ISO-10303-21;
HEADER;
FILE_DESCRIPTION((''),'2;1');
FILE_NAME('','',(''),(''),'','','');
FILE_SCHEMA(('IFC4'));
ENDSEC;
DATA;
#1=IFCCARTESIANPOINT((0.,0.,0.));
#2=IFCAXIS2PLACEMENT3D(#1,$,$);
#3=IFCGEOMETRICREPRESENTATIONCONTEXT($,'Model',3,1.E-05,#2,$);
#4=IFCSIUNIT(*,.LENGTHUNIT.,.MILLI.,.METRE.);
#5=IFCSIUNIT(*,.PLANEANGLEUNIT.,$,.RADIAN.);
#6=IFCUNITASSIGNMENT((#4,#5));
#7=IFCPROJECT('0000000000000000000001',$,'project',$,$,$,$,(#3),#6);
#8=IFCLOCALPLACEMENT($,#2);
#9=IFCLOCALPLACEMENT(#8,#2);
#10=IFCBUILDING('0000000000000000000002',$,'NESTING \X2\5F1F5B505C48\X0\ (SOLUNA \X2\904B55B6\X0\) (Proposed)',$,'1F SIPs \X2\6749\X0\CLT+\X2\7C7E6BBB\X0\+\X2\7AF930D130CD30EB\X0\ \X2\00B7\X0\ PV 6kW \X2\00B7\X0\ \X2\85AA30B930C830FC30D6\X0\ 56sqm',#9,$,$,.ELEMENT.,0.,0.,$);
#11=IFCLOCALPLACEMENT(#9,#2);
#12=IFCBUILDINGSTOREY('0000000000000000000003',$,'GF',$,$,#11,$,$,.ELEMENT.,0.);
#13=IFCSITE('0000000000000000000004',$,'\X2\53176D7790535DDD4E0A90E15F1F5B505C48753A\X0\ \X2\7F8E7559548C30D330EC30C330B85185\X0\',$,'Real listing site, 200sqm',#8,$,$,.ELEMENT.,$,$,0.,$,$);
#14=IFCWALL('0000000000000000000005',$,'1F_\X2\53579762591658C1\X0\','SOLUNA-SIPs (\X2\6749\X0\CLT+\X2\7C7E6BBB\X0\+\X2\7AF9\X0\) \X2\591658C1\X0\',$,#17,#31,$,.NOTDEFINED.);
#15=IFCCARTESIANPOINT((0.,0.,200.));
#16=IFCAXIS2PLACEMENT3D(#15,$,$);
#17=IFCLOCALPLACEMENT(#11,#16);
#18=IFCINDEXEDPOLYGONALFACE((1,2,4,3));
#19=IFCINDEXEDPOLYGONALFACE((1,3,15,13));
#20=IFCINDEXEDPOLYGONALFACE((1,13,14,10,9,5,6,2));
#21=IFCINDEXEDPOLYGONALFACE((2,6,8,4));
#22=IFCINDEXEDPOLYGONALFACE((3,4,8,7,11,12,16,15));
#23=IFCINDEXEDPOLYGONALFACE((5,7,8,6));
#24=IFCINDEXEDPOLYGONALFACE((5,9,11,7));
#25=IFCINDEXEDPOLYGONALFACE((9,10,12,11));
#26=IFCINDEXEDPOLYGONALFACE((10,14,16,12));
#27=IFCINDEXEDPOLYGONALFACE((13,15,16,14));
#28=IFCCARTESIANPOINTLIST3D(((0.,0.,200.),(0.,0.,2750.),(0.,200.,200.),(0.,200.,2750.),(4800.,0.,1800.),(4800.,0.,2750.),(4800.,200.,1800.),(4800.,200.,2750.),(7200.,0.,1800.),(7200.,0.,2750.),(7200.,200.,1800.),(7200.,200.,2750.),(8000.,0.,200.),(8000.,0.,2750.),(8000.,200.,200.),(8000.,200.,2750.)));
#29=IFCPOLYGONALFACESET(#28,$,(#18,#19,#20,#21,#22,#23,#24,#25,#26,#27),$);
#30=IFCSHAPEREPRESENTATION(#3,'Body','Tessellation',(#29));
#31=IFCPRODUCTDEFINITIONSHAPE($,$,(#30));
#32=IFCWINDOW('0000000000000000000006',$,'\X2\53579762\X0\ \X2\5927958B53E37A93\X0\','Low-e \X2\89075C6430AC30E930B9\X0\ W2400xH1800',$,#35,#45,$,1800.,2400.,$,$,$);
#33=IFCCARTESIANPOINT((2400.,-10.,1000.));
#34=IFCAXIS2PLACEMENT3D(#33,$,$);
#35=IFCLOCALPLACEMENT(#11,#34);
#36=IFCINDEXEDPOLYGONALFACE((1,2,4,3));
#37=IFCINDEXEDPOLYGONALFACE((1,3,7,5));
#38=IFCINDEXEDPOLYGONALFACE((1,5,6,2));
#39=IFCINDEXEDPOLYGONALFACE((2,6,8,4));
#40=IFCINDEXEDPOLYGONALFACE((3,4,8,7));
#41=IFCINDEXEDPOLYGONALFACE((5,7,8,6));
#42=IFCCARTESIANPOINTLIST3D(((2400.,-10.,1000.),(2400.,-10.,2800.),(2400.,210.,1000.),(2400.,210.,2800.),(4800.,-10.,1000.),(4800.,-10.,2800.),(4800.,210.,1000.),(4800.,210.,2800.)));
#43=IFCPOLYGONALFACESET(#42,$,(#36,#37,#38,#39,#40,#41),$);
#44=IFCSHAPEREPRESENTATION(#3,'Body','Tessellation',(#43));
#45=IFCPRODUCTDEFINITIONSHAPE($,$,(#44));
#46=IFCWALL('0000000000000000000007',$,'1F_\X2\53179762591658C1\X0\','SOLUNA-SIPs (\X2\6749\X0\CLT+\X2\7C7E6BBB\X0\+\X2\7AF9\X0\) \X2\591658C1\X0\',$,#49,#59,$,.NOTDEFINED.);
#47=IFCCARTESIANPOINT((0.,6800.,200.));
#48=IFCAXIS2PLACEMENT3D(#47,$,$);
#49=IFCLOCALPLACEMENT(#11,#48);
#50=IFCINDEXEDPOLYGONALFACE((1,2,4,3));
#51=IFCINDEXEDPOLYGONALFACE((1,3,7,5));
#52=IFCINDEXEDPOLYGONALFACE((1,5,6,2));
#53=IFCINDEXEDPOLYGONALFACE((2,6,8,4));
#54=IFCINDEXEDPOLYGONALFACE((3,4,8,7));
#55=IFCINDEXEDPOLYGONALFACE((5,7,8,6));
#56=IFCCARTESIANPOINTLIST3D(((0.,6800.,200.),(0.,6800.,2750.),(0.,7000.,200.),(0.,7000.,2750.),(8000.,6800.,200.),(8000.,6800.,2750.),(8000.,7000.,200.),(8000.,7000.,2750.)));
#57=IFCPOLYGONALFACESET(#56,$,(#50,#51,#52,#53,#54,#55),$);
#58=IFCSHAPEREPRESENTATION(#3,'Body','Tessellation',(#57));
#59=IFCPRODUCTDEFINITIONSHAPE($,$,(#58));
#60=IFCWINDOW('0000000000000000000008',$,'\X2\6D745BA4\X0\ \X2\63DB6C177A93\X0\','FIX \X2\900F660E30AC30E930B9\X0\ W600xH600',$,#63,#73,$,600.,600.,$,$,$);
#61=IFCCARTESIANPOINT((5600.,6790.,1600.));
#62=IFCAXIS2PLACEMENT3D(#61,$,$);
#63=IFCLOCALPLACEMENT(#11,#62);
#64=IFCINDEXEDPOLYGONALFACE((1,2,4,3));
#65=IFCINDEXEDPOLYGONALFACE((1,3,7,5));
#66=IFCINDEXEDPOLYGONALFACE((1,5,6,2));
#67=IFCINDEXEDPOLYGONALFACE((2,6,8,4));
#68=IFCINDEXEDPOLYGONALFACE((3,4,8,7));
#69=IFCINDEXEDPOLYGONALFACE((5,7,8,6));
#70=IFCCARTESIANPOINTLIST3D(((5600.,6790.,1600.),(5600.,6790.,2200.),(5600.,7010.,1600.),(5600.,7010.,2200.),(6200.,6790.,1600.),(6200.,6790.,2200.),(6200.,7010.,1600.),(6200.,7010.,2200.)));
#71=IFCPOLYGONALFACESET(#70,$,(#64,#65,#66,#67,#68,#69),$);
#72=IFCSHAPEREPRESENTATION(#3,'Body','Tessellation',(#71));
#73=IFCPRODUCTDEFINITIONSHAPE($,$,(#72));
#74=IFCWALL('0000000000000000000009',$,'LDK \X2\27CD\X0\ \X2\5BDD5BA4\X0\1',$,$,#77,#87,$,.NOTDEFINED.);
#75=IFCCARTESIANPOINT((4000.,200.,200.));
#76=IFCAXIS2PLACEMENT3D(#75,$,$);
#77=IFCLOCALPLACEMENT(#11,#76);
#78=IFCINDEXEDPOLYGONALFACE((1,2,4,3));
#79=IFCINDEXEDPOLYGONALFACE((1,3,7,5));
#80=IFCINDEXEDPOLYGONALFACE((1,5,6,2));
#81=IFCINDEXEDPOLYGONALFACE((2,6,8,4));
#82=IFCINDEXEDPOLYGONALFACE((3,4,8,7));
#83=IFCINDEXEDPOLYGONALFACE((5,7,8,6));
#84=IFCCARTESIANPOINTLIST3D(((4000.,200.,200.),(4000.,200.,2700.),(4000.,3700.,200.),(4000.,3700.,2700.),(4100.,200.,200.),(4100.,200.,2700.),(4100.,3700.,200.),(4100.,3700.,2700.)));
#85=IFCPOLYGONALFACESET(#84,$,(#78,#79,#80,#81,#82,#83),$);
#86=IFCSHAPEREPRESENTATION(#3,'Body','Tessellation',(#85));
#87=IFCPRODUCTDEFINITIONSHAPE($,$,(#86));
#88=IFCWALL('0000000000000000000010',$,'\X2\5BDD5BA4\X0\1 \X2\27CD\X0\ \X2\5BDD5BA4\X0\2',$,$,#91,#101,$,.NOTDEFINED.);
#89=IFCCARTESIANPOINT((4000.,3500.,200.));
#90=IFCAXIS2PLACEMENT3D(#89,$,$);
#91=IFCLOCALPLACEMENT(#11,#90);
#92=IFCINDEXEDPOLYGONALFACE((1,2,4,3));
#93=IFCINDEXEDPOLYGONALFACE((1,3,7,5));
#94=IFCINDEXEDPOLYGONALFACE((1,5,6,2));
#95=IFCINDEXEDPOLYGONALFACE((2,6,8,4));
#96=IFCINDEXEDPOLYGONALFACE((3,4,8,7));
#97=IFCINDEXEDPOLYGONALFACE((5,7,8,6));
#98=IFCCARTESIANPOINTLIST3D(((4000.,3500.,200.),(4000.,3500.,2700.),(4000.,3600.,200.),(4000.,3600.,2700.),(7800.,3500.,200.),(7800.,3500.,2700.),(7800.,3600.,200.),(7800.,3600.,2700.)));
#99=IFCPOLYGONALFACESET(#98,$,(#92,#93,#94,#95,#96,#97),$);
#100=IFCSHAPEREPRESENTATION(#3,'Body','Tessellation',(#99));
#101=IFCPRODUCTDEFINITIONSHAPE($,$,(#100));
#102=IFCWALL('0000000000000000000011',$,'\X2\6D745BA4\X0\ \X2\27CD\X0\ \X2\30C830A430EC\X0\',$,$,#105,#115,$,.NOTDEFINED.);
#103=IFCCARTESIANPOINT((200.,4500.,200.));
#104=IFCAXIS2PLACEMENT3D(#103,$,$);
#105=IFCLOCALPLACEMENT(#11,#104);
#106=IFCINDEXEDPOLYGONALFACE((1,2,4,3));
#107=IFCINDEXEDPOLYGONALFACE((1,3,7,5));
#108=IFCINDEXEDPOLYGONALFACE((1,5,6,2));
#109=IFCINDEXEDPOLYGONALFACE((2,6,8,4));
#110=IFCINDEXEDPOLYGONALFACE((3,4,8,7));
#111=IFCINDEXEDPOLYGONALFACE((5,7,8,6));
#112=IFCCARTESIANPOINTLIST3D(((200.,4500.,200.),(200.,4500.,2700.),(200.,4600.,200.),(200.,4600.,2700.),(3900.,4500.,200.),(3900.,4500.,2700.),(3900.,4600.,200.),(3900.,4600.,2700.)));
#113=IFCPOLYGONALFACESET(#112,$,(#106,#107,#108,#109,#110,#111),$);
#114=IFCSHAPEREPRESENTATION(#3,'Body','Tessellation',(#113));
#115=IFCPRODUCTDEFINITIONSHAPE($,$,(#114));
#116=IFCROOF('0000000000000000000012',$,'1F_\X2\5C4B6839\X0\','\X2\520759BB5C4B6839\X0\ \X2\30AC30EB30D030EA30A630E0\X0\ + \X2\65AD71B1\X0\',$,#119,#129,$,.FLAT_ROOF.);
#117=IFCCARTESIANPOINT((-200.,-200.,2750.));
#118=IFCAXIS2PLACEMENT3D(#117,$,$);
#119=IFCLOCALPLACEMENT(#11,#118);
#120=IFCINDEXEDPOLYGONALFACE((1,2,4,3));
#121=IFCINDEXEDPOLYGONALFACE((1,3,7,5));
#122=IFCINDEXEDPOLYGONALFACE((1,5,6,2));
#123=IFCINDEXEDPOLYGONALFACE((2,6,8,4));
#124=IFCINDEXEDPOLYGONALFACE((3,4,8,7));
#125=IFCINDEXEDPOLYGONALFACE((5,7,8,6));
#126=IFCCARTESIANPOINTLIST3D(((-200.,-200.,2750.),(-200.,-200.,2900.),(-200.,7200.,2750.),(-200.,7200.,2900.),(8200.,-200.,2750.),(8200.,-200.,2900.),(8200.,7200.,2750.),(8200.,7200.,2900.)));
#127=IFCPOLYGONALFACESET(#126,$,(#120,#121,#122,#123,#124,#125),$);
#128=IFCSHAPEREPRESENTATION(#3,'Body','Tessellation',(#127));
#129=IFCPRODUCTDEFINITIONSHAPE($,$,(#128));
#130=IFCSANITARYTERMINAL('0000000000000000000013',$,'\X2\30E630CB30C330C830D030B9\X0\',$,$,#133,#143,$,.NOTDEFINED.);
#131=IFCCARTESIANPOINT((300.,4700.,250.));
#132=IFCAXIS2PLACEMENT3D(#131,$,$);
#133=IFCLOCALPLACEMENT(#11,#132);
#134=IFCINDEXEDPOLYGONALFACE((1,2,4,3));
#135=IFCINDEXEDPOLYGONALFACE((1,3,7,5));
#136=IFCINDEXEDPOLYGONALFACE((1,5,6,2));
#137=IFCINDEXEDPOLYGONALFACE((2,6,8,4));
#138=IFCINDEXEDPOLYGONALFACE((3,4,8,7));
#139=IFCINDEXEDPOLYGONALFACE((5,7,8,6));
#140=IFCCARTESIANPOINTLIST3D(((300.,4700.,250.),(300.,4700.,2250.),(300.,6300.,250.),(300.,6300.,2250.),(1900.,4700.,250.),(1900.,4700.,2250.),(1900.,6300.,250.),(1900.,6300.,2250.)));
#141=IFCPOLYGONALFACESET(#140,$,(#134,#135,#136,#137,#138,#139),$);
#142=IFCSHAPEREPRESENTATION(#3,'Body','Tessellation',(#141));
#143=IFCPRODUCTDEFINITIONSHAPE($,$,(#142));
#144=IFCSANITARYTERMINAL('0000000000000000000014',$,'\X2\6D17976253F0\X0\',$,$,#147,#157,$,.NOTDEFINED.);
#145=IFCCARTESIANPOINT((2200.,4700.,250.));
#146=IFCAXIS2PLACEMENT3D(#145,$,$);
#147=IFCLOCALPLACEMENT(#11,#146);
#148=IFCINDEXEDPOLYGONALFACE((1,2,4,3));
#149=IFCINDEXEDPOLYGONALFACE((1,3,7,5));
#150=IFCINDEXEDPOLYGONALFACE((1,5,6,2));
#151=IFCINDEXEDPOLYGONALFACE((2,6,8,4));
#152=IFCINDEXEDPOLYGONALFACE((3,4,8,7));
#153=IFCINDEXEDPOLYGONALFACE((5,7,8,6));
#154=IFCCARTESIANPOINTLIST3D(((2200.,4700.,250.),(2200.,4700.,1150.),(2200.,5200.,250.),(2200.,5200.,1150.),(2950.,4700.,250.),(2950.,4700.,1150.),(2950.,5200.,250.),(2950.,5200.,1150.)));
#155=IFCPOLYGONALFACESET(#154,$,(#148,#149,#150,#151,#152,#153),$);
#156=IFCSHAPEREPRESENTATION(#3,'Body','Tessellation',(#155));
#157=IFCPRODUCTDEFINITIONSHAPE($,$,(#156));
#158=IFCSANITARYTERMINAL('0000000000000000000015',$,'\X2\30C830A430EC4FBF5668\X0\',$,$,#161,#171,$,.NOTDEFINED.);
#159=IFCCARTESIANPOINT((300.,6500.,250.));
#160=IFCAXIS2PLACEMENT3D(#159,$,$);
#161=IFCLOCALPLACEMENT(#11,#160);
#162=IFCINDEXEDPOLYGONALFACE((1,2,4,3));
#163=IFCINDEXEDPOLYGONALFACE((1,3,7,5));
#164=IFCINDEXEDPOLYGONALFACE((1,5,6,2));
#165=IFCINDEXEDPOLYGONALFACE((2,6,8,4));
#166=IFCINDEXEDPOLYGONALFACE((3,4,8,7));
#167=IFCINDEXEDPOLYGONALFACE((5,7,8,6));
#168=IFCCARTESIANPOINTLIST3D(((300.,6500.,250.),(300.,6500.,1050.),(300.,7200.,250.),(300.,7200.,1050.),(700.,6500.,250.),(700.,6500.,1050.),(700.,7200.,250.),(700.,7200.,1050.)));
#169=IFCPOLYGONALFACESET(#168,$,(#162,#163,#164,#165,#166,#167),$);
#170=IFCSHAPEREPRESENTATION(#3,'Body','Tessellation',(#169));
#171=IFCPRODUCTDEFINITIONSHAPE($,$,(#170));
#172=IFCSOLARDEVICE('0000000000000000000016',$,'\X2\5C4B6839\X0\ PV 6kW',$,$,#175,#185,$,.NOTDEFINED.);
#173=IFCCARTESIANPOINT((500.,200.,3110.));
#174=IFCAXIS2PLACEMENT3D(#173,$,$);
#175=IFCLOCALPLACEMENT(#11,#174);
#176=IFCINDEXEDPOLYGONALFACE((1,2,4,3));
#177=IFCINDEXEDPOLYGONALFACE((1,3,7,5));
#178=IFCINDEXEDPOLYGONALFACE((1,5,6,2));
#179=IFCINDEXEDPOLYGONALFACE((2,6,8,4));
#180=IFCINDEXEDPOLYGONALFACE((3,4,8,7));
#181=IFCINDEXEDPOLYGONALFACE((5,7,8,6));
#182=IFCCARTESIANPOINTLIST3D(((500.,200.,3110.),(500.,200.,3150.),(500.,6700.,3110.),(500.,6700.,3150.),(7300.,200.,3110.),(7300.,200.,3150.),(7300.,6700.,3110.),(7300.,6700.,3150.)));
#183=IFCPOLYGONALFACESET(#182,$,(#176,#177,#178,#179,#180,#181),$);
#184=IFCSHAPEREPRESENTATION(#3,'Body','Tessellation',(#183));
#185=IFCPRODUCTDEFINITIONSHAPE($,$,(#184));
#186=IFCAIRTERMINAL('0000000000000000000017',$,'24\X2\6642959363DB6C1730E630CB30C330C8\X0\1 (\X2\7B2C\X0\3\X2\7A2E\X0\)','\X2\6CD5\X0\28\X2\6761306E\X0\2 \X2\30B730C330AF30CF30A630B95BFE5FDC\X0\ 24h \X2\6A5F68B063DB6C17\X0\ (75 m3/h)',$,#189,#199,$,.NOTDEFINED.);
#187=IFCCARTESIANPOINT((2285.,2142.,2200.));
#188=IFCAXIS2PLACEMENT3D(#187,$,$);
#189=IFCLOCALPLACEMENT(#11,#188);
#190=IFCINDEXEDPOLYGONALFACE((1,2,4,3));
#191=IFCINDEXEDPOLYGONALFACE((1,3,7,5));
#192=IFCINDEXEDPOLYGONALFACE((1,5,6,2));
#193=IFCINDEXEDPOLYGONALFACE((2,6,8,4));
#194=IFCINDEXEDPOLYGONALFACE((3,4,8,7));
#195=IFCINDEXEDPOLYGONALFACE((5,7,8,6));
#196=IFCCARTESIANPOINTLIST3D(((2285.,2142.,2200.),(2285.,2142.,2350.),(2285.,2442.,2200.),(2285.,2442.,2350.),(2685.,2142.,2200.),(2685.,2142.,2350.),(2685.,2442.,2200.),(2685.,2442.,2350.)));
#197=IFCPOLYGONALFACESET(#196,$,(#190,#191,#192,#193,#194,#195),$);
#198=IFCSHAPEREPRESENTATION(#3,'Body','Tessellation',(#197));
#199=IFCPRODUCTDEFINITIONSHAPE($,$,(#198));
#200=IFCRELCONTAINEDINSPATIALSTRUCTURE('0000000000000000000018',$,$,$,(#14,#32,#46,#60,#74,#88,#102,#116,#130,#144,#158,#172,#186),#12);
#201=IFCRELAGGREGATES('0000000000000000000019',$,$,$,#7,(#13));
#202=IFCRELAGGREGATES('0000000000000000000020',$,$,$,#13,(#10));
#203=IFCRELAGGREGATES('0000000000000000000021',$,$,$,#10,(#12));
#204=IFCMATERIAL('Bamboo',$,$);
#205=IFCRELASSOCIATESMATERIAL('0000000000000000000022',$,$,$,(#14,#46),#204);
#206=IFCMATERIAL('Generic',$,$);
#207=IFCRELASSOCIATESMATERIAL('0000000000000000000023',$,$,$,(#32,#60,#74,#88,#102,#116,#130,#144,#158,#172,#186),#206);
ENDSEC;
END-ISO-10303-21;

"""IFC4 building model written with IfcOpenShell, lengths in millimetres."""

from ifc_helpers import new_model, si_unit, frame, frame_2d, origin, place, context, project, spatial, rectangle, extrude, material, element, fill, save


model = new_model("IFC4")

# Units and contexts
model_context = context("Model", 3, precision=1e-05, world=origin())
ifc_project = project(units=[si_unit("LENGTHUNIT", "METRE", prefix="MILLI"), si_unit("PLANEANGLEUNIT", "RADIAN")], contexts=[model_context])

# Site, building, storey
site_placement = place(None, origin())
site = spatial("IfcSite", under=ifc_project, at=site_placement, Name="北海道川上郡弟子屈町 美留和ビレッジ内", ObjectType="Real listing site, 200sqm", CompositionType="ELEMENT", RefElevation=0.0)
building_placement = place(site_placement, origin())
building = spatial("IfcBuilding", under=site, at=building_placement, Name="NESTING 弟子屈 (SOLUNA 運営) (Proposed)", ObjectType="1F SIPs 杉CLT+籾殻+竹パネル · PV 6kW · 薪ストーブ 56sqm", CompositionType="ELEMENT", ElevationOfRefHeight=0.0, ElevationOfTerrain=0.0)
storey_placement = place(building_placement, origin())
storey = spatial("IfcBuildingStorey", under=building, at=storey_placement, Name="GF", CompositionType="ELEMENT", Elevation=0.0)

# Walls, openings, windows
ifc_material_1 = material(Name="Bamboo")
wall_1_placement = place(storey_placement, frame((0.0, 0.0, 200.0)))
wall_1 = element("IfcWall", 1, at=wall_1_placement, inside=storey, material=ifc_material_1, Name="1F_南面外壁", Description="SOLUNA-SIPs (杉CLT+籾殻+竹) 外壁", PredefinedType="NOTDEFINED", context=model_context, shape_type="SweptSolid", body=[
    extrude(rectangle(XDim=8000.0, YDim=200.0, at=frame_2d((4000.0, 100.0))), frame((0.0, 0.0, 200.0)), (0.0, 0.0, 1.0), 2550.0),
])
opening_1_placement = place(storey_placement, frame((2400.0, -10.0, 1000.0)))
opening_1 = element("IfcOpeningElement", 2, at=opening_1_placement, cuts=wall_1, PredefinedType="NOTDEFINED", context=model_context, shape_type="SweptSolid", body=[
    extrude(rectangle(XDim=2400.0, YDim=220.0, at=frame_2d((1200.0, 110.0))), frame((2400.0, -10.0, 1000.0)), (0.0, 0.0, 1.0), 1800.0),
])
ifc_material_2 = material(Name="Generic")
window_1_placement = place(storey_placement, frame((2400.0, -10.0, 1000.0)))
window_1 = element("IfcWindow", 3, at=window_1_placement, inside=storey, material=ifc_material_2, Name="南面 大開口窓", Description="Low-e 複層ガラス W2400xH1800", OverallHeight=1800.0, OverallWidth=2400.0, context=model_context, shape_type="SweptSolid", body=[
    extrude(rectangle(XDim=2400.0, YDim=220.0, at=frame_2d((1200.0, 110.0))), frame((2400.0, -10.0, 1000.0)), (0.0, 0.0, 1.0), 1800.0),
])
fill(opening_1, window_1)
wall_2_placement = place(storey_placement, frame((0.0, 6800.0, 200.0)))
wall_2 = element("IfcWall", 4, at=wall_2_placement, inside=storey, material=ifc_material_1, Name="1F_北面外壁", Description="SOLUNA-SIPs (杉CLT+籾殻+竹) 外壁", PredefinedType="NOTDEFINED", context=model_context, shape_type="SweptSolid", body=[
    extrude(rectangle(XDim=8000.0, YDim=200.0, at=frame_2d((4000.0, 100.0))), frame((0.0, 6800.0, 200.0)), (0.0, 0.0, 1.0), 2550.0),
])
opening_2_placement = place(storey_placement, frame((5600.0, 6790.0, 1600.0)))
opening_2 = element("IfcOpeningElement", 5, at=opening_2_placement, cuts=wall_2, PredefinedType="NOTDEFINED", context=model_context, shape_type="SweptSolid", body=[
    extrude(rectangle(XDim=600.0, YDim=220.0, at=frame_2d((300.0, 110.0))), frame((5600.0, 6790.0, 1600.0)), (0.0, 0.0, 1.0), 600.0),
])
window_2_placement = place(storey_placement, frame((5600.0, 6790.0, 1600.0)))
window_2 = element("IfcWindow", 6, at=window_2_placement, inside=storey, material=ifc_material_2, Name="浴室 換気窓", Description="FIX 透明ガラス W600xH600", OverallHeight=600.0, OverallWidth=600.0, context=model_context, shape_type="SweptSolid", body=[
    extrude(rectangle(XDim=600.0, YDim=220.0, at=frame_2d((300.0, 110.0))), frame((5600.0, 6790.0, 1600.0)), (0.0, 0.0, 1.0), 600.0),
])
fill(opening_2, window_2)

# Walls
wall_3_placement = place(storey_placement, frame((4000.0, 200.0, 200.0)))
element("IfcWall", 7, at=wall_3_placement, inside=storey, material=ifc_material_2, Name="LDK ⟍ 寝室1", PredefinedType="NOTDEFINED", context=model_context, shape_type="SweptSolid", body=[
    extrude(rectangle(XDim=100.0, YDim=3500.0, at=frame_2d((50.0, 1750.0))), frame((4000.0, 200.0, 200.0)), (0.0, 0.0, 1.0), 2500.0),
])
wall_4_placement = place(storey_placement, frame((4000.0, 3500.0, 200.0)))
element("IfcWall", 8, at=wall_4_placement, inside=storey, material=ifc_material_2, Name="寝室1 ⟍ 寝室2", PredefinedType="NOTDEFINED", context=model_context, shape_type="SweptSolid", body=[
    extrude(rectangle(XDim=3800.0, YDim=100.0, at=frame_2d((1900.0, 50.0))), frame((4000.0, 3500.0, 200.0)), (0.0, 0.0, 1.0), 2500.0),
])
wall_5_placement = place(storey_placement, frame((200.0, 4500.0, 200.0)))
element("IfcWall", 9, at=wall_5_placement, inside=storey, material=ifc_material_2, Name="浴室 ⟍ トイレ", PredefinedType="NOTDEFINED", context=model_context, shape_type="SweptSolid", body=[
    extrude(rectangle(XDim=3700.0, YDim=100.0, at=frame_2d((1850.0, 50.0))), frame((200.0, 4500.0, 200.0)), (0.0, 0.0, 1.0), 2500.0),
])

# Roof
roof_placement = place(storey_placement, frame((-200.0, -200.0, 2750.0)))
element("IfcRoof", 10, at=roof_placement, inside=storey, material=ifc_material_2, Name="1F_屋根", Description="切妻屋根 ガルバリウム + 断熱", PredefinedType="FLAT_ROOF", context=model_context, shape_type="SweptSolid", body=[
    extrude(rectangle(XDim=8400.0, YDim=7400.0, at=frame_2d((4200.0, 3700.0))), frame((-200.0, -200.0, 2750.0)), (0.0, 0.0, 1.0), 150.0),
])

# Sanitary terminals
sanitary_terminal_1_placement = place(storey_placement, frame((300.0, 4700.0, 250.0)))
element("IfcSanitaryTerminal", 11, at=sanitary_terminal_1_placement, inside=storey, material=ifc_material_2, Name="ユニットバス", PredefinedType="NOTDEFINED", context=model_context, shape_type="SweptSolid", body=[
    extrude(rectangle(XDim=1600.0, YDim=1600.0, at=frame_2d((800.0, 800.0))), frame((300.0, 4700.0, 250.0)), (0.0, 0.0, 1.0), 2000.0),
])
sanitary_terminal_2_placement = place(storey_placement, frame((2200.0, 4700.0, 250.0)))
element("IfcSanitaryTerminal", 12, at=sanitary_terminal_2_placement, inside=storey, material=ifc_material_2, Name="洗面台", PredefinedType="NOTDEFINED", context=model_context, shape_type="SweptSolid", body=[
    extrude(rectangle(XDim=750.0, YDim=500.0, at=frame_2d((375.0, 250.0))), frame((2200.0, 4700.0, 250.0)), (0.0, 0.0, 1.0), 900.0),
])
sanitary_terminal_3_placement = place(storey_placement, frame((300.0, 6500.0, 250.0)))
element("IfcSanitaryTerminal", 13, at=sanitary_terminal_3_placement, inside=storey, material=ifc_material_2, Name="トイレ便器", PredefinedType="NOTDEFINED", context=model_context, shape_type="SweptSolid", body=[
    extrude(rectangle(XDim=400.0, YDim=700.0, at=frame_2d((200.0, 350.0))), frame((300.0, 6500.0, 250.0)), (0.0, 0.0, 1.0), 800.0),
])

# Solar device
solar_device_placement = place(storey_placement, frame((500.0, 200.0, 3110.0)))
element("IfcSolarDevice", 14, at=solar_device_placement, inside=storey, material=ifc_material_2, Name="屋根 PV 6kW", PredefinedType="NOTDEFINED", context=model_context, shape_type="SweptSolid", body=[
    extrude(rectangle(XDim=6800.0, YDim=6500.0, at=frame_2d((3400.0, 3250.0))), frame((500.0, 200.0, 3110.0)), (0.0, 0.0, 1.0), 40.0),
])

# Air terminal
air_terminal_1_placement = place(storey_placement, frame((2285.0, 2142.0, 2200.0)))
element("IfcAirTerminal", 15, at=air_terminal_1_placement, inside=storey, material=ifc_material_2, Name="24時間換気ユニット1 (第3種)", Description="法28条の2 シックハウス対応 24h 機械換気 (75 m3/h)", PredefinedType="NOTDEFINED", context=model_context, shape_type="SweptSolid", body=[
    extrude(rectangle(XDim=400.0, YDim=300.0, at=frame_2d((200.0, 150.0))), frame((2285.0, 2142.0, 2200.0)), (0.0, 0.0, 1.0), 150.0),
])

save(model, "model.ifc")
